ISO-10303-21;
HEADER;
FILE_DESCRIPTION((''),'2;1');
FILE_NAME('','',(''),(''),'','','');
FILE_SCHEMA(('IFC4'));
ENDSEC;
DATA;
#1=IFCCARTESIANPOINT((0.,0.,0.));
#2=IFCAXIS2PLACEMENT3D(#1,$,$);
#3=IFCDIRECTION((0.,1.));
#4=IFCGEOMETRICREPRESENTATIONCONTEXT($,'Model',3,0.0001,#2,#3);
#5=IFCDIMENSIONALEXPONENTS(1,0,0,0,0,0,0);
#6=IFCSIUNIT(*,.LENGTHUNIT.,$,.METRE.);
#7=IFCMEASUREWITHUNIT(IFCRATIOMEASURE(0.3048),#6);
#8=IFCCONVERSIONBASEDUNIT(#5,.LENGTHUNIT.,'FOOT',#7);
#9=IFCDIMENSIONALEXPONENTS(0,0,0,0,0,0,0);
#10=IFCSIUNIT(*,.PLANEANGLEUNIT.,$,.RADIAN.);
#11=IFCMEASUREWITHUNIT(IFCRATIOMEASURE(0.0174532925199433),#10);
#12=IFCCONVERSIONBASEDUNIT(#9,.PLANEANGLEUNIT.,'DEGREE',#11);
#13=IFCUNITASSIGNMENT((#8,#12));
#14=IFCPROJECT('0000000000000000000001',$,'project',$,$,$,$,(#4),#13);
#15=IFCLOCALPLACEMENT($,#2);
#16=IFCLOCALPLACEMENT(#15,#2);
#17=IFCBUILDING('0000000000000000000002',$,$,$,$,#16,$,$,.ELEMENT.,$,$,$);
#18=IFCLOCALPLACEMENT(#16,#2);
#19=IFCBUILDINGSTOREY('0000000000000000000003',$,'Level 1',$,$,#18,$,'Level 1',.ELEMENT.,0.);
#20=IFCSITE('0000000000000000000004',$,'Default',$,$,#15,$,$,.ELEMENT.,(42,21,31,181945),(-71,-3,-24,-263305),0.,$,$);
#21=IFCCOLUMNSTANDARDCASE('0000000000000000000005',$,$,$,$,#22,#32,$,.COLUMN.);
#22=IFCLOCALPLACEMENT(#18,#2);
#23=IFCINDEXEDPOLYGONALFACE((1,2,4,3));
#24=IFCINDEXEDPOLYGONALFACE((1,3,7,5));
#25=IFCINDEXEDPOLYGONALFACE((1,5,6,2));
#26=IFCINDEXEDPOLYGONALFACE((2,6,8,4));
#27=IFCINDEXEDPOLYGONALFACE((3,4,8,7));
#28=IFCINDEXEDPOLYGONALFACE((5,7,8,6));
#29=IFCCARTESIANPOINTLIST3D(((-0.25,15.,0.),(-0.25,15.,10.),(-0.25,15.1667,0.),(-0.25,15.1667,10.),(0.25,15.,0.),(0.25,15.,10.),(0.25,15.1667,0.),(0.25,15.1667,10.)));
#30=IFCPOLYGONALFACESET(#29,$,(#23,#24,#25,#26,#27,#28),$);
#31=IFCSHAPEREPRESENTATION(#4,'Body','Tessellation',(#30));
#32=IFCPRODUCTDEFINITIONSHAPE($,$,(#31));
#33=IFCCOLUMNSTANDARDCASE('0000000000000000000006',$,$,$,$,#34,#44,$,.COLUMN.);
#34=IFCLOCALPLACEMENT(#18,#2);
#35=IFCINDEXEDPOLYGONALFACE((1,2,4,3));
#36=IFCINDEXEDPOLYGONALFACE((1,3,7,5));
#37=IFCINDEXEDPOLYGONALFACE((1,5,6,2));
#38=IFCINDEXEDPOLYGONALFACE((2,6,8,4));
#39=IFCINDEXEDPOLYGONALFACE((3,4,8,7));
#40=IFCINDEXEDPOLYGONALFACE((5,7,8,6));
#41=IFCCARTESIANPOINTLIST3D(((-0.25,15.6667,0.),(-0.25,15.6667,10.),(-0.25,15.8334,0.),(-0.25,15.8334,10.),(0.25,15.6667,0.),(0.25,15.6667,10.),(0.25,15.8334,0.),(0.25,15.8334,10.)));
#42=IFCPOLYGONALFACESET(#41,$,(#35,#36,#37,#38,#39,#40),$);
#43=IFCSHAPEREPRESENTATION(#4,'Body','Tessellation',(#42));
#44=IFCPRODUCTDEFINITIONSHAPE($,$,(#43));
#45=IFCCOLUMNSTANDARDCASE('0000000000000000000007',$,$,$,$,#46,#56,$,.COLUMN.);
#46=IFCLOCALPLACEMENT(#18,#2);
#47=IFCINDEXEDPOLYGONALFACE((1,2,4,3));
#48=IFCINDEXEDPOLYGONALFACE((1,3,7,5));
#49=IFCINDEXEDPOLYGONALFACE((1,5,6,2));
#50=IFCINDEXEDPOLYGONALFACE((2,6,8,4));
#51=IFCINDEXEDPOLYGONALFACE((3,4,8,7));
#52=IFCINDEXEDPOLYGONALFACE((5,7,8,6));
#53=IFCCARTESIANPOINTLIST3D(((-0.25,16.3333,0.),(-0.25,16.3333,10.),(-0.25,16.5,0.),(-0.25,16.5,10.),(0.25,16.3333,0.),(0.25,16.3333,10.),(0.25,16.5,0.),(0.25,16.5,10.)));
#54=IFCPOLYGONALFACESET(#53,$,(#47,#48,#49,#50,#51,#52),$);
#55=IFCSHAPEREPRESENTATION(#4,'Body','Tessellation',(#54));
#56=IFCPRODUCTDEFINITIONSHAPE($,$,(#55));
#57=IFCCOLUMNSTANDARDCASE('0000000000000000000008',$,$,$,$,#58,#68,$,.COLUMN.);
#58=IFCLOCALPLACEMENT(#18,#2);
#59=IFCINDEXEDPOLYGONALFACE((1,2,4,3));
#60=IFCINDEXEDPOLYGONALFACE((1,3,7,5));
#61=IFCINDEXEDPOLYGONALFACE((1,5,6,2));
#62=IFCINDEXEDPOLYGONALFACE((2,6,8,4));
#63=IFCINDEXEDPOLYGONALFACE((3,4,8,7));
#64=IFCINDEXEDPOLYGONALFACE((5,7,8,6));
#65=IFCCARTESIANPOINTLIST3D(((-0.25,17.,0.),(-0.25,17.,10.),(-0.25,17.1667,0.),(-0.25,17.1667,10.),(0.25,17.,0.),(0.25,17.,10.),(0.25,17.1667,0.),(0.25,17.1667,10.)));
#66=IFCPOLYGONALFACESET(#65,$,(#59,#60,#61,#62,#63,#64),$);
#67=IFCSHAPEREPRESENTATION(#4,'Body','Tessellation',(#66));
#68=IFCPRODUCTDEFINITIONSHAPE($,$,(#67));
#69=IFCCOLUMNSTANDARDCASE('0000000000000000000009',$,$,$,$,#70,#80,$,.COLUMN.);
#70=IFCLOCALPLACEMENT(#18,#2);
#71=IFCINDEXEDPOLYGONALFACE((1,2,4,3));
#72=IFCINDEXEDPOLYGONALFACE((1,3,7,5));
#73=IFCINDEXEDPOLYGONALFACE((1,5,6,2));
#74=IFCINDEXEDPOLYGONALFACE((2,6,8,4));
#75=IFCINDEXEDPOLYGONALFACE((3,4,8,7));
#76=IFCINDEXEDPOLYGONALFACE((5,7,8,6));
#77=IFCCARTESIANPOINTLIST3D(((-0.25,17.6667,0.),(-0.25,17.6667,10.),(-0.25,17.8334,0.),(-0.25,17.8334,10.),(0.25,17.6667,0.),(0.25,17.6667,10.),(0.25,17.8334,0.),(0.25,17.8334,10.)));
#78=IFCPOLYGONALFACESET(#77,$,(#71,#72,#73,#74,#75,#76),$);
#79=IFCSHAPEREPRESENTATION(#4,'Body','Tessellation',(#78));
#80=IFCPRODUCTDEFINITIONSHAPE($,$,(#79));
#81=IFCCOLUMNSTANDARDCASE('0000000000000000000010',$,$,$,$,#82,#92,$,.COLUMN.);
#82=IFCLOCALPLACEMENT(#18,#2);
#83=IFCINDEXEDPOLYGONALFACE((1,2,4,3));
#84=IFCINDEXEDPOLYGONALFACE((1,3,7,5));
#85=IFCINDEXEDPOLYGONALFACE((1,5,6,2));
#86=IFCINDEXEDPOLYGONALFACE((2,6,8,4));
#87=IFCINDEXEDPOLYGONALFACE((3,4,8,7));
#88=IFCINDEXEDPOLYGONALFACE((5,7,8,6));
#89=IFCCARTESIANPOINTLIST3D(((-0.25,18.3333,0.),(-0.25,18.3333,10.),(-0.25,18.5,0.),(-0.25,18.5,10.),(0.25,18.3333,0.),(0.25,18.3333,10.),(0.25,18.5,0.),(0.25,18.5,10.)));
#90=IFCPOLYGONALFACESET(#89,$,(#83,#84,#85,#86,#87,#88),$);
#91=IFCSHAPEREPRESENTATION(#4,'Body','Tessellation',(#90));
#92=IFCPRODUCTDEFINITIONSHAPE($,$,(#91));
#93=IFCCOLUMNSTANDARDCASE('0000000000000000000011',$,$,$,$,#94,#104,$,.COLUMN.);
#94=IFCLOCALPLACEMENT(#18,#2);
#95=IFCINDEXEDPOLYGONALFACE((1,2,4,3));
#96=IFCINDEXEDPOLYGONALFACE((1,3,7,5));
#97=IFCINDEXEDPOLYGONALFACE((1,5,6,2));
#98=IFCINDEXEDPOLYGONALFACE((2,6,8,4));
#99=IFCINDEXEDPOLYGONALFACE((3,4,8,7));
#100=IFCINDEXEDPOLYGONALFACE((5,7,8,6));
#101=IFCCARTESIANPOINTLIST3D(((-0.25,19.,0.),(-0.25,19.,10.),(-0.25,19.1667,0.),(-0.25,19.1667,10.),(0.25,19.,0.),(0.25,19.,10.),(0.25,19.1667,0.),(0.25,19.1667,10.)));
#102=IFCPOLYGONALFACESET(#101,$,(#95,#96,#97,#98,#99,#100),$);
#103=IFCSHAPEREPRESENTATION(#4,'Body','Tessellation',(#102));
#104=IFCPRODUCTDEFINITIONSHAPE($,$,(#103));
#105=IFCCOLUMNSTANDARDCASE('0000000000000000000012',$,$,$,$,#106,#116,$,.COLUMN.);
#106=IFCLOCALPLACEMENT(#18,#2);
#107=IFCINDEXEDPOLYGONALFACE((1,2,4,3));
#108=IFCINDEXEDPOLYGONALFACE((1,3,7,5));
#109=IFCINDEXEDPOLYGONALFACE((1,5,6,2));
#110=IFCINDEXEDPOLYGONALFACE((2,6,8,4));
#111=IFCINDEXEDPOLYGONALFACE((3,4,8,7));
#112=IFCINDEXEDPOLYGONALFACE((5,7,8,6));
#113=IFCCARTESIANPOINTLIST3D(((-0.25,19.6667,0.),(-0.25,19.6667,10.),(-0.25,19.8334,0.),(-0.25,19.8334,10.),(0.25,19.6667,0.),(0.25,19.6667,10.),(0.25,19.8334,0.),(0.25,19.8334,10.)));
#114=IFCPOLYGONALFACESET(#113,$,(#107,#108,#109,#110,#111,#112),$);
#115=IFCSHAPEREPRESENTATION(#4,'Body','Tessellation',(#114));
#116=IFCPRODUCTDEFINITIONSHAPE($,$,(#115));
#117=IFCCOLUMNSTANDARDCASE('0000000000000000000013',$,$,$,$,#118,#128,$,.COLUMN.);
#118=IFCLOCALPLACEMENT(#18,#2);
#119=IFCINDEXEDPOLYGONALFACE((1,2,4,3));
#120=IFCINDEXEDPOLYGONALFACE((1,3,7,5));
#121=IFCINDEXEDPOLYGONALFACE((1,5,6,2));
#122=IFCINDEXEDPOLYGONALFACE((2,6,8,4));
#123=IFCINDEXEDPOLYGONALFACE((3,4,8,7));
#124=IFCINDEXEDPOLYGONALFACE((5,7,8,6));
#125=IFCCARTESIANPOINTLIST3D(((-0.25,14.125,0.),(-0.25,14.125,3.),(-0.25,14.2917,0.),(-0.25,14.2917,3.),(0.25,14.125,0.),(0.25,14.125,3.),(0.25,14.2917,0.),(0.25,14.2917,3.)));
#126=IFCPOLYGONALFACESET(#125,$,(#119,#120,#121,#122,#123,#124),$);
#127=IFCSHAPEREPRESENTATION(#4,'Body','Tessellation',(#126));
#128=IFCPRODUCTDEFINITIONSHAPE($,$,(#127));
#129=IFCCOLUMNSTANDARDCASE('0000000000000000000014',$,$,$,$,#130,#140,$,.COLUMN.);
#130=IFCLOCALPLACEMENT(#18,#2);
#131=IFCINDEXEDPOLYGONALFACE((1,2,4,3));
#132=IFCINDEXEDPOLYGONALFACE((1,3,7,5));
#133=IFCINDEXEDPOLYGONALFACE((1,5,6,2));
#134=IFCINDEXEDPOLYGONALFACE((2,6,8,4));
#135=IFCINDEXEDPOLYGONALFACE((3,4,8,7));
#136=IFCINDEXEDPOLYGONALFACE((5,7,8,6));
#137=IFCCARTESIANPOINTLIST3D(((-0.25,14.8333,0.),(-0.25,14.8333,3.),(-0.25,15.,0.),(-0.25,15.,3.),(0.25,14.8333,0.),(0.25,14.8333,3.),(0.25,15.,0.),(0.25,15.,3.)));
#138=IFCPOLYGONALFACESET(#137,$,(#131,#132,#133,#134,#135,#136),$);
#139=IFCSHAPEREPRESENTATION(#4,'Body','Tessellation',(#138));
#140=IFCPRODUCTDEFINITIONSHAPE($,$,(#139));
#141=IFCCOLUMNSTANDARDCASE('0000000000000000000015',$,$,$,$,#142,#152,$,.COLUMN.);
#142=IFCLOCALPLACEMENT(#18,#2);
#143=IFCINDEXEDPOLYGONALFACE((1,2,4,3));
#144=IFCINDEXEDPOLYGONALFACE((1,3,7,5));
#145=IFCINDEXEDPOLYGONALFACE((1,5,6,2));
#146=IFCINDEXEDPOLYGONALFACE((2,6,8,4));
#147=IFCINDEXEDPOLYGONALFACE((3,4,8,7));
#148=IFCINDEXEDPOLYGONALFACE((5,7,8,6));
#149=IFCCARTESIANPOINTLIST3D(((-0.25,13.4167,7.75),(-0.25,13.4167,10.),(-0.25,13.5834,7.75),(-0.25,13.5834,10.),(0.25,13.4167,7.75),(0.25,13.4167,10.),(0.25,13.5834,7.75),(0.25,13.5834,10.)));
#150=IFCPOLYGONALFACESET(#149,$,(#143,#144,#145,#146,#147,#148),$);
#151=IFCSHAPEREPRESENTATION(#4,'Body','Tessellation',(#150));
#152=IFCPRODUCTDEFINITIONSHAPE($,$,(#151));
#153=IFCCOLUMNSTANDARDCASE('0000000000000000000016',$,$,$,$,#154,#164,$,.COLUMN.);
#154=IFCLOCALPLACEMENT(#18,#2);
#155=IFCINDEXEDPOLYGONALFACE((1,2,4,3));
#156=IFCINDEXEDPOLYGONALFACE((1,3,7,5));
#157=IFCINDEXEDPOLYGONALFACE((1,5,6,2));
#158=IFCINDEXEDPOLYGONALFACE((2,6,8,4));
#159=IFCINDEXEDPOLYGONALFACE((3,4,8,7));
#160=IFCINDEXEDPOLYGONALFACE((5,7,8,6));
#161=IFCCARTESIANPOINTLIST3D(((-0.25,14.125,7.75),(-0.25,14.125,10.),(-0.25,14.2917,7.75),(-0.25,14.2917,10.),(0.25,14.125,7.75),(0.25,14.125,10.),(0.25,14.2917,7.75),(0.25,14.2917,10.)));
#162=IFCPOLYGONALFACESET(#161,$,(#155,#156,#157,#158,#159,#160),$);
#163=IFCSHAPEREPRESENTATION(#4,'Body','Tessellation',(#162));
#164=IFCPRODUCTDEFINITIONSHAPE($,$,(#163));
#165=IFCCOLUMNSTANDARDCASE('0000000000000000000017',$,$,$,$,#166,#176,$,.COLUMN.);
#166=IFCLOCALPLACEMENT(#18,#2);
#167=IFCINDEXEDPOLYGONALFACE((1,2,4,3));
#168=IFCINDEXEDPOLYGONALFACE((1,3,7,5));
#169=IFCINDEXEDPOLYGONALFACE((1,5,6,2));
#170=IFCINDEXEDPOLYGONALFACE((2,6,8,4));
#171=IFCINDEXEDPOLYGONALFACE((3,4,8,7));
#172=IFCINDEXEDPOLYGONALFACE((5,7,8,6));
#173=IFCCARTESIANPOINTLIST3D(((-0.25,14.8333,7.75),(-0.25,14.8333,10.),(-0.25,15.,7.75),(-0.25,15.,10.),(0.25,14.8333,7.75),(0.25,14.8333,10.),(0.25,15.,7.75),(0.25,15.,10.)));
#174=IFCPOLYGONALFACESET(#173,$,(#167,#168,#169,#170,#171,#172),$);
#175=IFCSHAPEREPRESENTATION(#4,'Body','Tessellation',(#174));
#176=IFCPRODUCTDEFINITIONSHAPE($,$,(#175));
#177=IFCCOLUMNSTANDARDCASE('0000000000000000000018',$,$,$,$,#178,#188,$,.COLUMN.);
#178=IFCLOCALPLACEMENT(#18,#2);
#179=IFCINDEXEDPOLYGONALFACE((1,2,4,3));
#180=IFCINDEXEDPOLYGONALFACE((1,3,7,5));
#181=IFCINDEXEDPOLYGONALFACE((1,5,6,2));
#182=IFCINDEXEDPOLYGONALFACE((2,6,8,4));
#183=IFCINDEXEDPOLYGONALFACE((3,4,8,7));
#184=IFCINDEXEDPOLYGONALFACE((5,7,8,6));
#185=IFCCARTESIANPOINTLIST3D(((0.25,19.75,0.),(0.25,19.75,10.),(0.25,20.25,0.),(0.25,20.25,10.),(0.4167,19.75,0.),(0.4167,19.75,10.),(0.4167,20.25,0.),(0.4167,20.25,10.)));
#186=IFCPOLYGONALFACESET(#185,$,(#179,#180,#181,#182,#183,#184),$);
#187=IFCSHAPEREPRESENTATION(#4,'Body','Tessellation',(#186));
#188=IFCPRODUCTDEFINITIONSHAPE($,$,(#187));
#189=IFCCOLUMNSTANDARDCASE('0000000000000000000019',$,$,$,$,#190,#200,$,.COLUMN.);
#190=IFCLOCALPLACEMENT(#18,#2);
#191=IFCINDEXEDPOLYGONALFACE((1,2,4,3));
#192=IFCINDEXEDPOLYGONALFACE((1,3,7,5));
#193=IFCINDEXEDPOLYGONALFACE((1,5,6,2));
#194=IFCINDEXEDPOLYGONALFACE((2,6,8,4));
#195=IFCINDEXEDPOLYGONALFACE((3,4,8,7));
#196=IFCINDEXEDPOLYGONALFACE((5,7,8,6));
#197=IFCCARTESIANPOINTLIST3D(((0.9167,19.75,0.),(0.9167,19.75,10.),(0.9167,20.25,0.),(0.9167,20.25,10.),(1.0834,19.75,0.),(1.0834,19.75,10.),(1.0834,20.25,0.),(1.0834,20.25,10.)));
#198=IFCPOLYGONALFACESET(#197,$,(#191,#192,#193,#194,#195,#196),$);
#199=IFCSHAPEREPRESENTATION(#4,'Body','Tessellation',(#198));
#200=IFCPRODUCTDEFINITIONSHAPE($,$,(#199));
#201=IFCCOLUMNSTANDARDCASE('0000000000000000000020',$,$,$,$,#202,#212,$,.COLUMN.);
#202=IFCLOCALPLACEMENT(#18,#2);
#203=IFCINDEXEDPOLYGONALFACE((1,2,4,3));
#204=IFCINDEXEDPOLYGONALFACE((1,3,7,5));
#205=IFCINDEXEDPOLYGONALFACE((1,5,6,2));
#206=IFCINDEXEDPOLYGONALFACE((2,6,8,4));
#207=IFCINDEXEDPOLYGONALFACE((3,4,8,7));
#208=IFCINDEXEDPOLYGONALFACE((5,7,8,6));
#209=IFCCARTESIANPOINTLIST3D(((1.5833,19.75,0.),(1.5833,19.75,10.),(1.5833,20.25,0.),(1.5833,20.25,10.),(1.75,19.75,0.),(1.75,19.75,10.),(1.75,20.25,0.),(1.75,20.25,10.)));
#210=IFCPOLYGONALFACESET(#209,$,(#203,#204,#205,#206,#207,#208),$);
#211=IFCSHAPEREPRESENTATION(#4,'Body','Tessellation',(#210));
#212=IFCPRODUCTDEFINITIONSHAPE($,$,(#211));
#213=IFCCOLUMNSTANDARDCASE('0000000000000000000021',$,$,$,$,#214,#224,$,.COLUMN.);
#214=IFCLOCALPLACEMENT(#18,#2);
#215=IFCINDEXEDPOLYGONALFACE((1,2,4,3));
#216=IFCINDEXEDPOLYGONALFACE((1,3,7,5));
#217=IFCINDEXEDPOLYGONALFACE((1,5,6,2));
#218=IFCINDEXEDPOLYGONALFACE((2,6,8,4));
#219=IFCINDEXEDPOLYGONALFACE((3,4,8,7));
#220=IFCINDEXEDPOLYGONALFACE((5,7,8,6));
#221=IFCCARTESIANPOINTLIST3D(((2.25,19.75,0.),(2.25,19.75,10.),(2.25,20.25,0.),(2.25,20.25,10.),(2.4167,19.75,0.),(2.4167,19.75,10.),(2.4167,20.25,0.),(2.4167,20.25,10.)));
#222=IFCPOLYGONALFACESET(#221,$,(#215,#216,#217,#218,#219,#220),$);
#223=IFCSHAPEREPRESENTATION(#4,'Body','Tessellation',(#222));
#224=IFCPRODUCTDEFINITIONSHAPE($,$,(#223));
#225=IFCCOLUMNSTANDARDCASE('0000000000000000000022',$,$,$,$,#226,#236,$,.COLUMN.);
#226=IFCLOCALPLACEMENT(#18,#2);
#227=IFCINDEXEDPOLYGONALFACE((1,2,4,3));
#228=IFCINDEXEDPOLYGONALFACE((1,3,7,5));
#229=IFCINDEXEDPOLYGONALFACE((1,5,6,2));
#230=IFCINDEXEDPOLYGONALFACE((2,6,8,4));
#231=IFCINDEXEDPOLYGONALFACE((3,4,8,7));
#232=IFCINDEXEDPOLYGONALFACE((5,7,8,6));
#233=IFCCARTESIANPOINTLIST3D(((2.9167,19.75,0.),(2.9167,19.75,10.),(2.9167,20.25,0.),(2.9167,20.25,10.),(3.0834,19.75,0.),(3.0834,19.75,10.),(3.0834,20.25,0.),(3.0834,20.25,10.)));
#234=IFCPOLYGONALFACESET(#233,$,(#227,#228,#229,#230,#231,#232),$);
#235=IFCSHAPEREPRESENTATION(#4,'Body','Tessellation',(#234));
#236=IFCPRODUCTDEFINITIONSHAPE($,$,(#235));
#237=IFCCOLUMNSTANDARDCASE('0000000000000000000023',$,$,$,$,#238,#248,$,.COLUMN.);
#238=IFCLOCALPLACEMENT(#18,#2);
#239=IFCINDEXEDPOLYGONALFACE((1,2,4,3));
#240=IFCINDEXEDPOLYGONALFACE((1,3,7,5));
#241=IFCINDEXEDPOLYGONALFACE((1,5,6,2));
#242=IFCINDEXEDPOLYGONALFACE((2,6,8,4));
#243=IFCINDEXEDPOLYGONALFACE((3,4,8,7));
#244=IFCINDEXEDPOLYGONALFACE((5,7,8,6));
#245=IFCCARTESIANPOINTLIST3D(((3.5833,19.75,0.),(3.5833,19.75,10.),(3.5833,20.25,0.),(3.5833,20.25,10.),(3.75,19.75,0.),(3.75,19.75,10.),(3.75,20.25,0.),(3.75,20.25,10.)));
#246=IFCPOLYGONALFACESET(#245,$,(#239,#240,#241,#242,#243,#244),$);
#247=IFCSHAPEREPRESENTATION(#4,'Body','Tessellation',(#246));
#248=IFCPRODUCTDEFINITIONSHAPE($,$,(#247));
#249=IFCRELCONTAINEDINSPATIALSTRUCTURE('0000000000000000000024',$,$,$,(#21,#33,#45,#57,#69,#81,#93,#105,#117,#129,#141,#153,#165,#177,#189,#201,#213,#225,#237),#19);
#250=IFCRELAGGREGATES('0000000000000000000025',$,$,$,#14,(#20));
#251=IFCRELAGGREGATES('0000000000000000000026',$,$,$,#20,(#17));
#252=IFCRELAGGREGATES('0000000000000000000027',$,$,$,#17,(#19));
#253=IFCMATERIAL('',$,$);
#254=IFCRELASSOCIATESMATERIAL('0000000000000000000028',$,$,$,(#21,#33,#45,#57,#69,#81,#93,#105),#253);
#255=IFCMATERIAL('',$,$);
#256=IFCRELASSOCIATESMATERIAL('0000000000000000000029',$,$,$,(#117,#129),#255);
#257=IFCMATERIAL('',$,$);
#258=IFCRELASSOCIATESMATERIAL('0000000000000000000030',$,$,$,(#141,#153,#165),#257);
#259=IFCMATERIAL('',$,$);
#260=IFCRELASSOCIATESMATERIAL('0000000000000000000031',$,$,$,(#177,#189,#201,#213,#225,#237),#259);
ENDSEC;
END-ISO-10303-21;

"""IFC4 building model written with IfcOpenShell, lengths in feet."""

from ifc_helpers import new_model, entity, si_unit, converted_unit, direction, frame, origin, place, context, project, spatial, rectangle, extrude, material, element, save


model = new_model("IFC4")

# Units and contexts
model_context = context("Model", 3, precision=0.0001, world=origin(), true_north=direction((0.0, 1.0)))
ifc_project = project(units=[converted_unit("LENGTHUNIT", "FOOT", entity("IfcRatioMeasure", 0.3048), si_unit("LENGTHUNIT", "METRE"), dimensions=[1, 0, 0, 0, 0, 0, 0]), converted_unit("PLANEANGLEUNIT", "DEGREE", entity("IfcRatioMeasure", 0.0174532925199433), si_unit("PLANEANGLEUNIT", "RADIAN"), dimensions=[0, 0, 0, 0, 0, 0, 0])], contexts=[model_context])

# Site, building, storey
site_placement = place(None, origin())
site = spatial("IfcSite", under=ifc_project, at=site_placement, Name="Default", CompositionType="ELEMENT", RefLatitude=(42, 21, 31, 181945), RefLongitude=(-71, -3, -24, -263305), RefElevation=0.0)
building_placement = place(site_placement, origin())
building = spatial("IfcBuilding", under=site, at=building_placement, CompositionType="ELEMENT")
storey_placement = place(building_placement, origin())
storey = spatial("IfcBuildingStorey", under=building, at=storey_placement, Name="Level 1", LongName="Level 1", CompositionType="ELEMENT", Elevation=0.0)

# Columns
ifc_material_1 = material(Name="")
placement = place(storey_placement, frame((0.0, -0.25, 0.0), z_axis=(0.0, 0.0, 1.0), x_axis=(0.0, 1.0, 0.0)))
for number, where, z_axis, x_axis in (
    (1, (15.3334, 0.0, 0.0), (0.0, 0.0, 1.0), (1.0, 0.0, 0.0)),
    (2, (16.0, 0.0, 0.0), (0.0, 0.0, 1.0), (1.0, 0.0, 0.0)),
    (3, (16.6667, 0.0, 0.0), (0.0, 0.0, 1.0), (1.0, 0.0, 0.0)),
    (4, (17.3333, 0.0, 0.0), (0.0, 0.0, 1.0), (1.0, 0.0, 0.0)),
    (5, (18.0, 0.0, 0.0), (0.0, 0.0, 1.0), (1.0, 0.0, 0.0)),
    (6, (18.6667, 0.0, 0.0), (0.0, 0.0, 1.0), (1.0, 0.0, 0.0)),
    (7, (19.3333, 0.0, 0.0), (0.0, 0.0, 1.0), (1.0, 0.0, 0.0)),
    (8, (20.0, 0.0, 0.0), (0.0, 0.0, 1.0), (1.0, 0.0, 0.0)),
):
    element("IfcColumnStandardCase", number, at=place(placement, frame(where, z_axis=z_axis, x_axis=x_axis)), inside=storey, material=ifc_material_1, PredefinedType="COLUMN", context=model_context, shape_type="SweptSolid", body=[
        extrude(rectangle(XDim=0.1667, YDim=0.5), origin(), (0.0, 0.0, 1.0), 10.0),
    ])
ifc_material_2 = material(Name="")
for number, where, z_axis, x_axis in (
    (9, (14.4583, 0.0, 0.0), (0.0, 0.0, 1.0), (1.0, 0.0, 0.0)),
    (10, (15.1667, 0.0, 0.0), (0.0, 0.0, 1.0), (1.0, 0.0, 0.0)),
):
    element("IfcColumnStandardCase", number, at=place(placement, frame(where, z_axis=z_axis, x_axis=x_axis)), inside=storey, material=ifc_material_2, PredefinedType="COLUMN", context=model_context, shape_type="SweptSolid", body=[
        extrude(rectangle(XDim=0.1667, YDim=0.5), origin(), (0.0, 0.0, 1.0), 3.0),
    ])
ifc_material_3 = material(Name="")
for number, where, z_axis, x_axis in (
    (11, (13.75, 0.0, 7.75), (0.0, 0.0, 1.0), (1.0, 0.0, 0.0)),
    (12, (14.4583, 0.0, 7.75), (0.0, 0.0, 1.0), (1.0, 0.0, 0.0)),
    (13, (15.1667, 0.0, 7.75), (0.0, 0.0, 1.0), (1.0, 0.0, 0.0)),
):
    element("IfcColumnStandardCase", number, at=place(placement, frame(where, z_axis=z_axis, x_axis=x_axis)), inside=storey, material=ifc_material_3, PredefinedType="COLUMN", context=model_context, shape_type="SweptSolid", body=[
        extrude(rectangle(XDim=0.1667, YDim=0.5), origin(), (0.0, 0.0, 1.0), 2.25),
    ])
ifc_material_4 = material(Name="")
wall_placement = place(storey_placement, frame((0.25, 20.0, 0.0)))
for number, where, z_axis, x_axis in (
    (14, (0.0833, 0.0, 0.0), (0.0, 0.0, 1.0), (1.0, 0.0, 0.0)),
    (15, (0.75, 0.0, 0.0), (0.0, 0.0, 1.0), (1.0, 0.0, 0.0)),
    (16, (1.4167, 0.0, 0.0), (0.0, 0.0, 1.0), (1.0, 0.0, 0.0)),
    (17, (2.0833, 0.0, 0.0), (0.0, 0.0, 1.0), (1.0, 0.0, 0.0)),
    (18, (2.75, 0.0, 0.0), (0.0, 0.0, 1.0), (1.0, 0.0, 0.0)),
    (19, (3.4167, 0.0, 0.0), (0.0, 0.0, 1.0), (1.0, 0.0, 0.0)),
):
    element("IfcColumnStandardCase", number, at=place(wall_placement, frame(where, z_axis=z_axis, x_axis=x_axis)), inside=storey, material=ifc_material_4, PredefinedType="COLUMN", context=model_context, shape_type="SweptSolid", body=[
        extrude(rectangle(XDim=0.1667, YDim=0.5), origin(), (0.0, 0.0, 1.0), 10.0),
    ])

save(model, "model.ifc")
